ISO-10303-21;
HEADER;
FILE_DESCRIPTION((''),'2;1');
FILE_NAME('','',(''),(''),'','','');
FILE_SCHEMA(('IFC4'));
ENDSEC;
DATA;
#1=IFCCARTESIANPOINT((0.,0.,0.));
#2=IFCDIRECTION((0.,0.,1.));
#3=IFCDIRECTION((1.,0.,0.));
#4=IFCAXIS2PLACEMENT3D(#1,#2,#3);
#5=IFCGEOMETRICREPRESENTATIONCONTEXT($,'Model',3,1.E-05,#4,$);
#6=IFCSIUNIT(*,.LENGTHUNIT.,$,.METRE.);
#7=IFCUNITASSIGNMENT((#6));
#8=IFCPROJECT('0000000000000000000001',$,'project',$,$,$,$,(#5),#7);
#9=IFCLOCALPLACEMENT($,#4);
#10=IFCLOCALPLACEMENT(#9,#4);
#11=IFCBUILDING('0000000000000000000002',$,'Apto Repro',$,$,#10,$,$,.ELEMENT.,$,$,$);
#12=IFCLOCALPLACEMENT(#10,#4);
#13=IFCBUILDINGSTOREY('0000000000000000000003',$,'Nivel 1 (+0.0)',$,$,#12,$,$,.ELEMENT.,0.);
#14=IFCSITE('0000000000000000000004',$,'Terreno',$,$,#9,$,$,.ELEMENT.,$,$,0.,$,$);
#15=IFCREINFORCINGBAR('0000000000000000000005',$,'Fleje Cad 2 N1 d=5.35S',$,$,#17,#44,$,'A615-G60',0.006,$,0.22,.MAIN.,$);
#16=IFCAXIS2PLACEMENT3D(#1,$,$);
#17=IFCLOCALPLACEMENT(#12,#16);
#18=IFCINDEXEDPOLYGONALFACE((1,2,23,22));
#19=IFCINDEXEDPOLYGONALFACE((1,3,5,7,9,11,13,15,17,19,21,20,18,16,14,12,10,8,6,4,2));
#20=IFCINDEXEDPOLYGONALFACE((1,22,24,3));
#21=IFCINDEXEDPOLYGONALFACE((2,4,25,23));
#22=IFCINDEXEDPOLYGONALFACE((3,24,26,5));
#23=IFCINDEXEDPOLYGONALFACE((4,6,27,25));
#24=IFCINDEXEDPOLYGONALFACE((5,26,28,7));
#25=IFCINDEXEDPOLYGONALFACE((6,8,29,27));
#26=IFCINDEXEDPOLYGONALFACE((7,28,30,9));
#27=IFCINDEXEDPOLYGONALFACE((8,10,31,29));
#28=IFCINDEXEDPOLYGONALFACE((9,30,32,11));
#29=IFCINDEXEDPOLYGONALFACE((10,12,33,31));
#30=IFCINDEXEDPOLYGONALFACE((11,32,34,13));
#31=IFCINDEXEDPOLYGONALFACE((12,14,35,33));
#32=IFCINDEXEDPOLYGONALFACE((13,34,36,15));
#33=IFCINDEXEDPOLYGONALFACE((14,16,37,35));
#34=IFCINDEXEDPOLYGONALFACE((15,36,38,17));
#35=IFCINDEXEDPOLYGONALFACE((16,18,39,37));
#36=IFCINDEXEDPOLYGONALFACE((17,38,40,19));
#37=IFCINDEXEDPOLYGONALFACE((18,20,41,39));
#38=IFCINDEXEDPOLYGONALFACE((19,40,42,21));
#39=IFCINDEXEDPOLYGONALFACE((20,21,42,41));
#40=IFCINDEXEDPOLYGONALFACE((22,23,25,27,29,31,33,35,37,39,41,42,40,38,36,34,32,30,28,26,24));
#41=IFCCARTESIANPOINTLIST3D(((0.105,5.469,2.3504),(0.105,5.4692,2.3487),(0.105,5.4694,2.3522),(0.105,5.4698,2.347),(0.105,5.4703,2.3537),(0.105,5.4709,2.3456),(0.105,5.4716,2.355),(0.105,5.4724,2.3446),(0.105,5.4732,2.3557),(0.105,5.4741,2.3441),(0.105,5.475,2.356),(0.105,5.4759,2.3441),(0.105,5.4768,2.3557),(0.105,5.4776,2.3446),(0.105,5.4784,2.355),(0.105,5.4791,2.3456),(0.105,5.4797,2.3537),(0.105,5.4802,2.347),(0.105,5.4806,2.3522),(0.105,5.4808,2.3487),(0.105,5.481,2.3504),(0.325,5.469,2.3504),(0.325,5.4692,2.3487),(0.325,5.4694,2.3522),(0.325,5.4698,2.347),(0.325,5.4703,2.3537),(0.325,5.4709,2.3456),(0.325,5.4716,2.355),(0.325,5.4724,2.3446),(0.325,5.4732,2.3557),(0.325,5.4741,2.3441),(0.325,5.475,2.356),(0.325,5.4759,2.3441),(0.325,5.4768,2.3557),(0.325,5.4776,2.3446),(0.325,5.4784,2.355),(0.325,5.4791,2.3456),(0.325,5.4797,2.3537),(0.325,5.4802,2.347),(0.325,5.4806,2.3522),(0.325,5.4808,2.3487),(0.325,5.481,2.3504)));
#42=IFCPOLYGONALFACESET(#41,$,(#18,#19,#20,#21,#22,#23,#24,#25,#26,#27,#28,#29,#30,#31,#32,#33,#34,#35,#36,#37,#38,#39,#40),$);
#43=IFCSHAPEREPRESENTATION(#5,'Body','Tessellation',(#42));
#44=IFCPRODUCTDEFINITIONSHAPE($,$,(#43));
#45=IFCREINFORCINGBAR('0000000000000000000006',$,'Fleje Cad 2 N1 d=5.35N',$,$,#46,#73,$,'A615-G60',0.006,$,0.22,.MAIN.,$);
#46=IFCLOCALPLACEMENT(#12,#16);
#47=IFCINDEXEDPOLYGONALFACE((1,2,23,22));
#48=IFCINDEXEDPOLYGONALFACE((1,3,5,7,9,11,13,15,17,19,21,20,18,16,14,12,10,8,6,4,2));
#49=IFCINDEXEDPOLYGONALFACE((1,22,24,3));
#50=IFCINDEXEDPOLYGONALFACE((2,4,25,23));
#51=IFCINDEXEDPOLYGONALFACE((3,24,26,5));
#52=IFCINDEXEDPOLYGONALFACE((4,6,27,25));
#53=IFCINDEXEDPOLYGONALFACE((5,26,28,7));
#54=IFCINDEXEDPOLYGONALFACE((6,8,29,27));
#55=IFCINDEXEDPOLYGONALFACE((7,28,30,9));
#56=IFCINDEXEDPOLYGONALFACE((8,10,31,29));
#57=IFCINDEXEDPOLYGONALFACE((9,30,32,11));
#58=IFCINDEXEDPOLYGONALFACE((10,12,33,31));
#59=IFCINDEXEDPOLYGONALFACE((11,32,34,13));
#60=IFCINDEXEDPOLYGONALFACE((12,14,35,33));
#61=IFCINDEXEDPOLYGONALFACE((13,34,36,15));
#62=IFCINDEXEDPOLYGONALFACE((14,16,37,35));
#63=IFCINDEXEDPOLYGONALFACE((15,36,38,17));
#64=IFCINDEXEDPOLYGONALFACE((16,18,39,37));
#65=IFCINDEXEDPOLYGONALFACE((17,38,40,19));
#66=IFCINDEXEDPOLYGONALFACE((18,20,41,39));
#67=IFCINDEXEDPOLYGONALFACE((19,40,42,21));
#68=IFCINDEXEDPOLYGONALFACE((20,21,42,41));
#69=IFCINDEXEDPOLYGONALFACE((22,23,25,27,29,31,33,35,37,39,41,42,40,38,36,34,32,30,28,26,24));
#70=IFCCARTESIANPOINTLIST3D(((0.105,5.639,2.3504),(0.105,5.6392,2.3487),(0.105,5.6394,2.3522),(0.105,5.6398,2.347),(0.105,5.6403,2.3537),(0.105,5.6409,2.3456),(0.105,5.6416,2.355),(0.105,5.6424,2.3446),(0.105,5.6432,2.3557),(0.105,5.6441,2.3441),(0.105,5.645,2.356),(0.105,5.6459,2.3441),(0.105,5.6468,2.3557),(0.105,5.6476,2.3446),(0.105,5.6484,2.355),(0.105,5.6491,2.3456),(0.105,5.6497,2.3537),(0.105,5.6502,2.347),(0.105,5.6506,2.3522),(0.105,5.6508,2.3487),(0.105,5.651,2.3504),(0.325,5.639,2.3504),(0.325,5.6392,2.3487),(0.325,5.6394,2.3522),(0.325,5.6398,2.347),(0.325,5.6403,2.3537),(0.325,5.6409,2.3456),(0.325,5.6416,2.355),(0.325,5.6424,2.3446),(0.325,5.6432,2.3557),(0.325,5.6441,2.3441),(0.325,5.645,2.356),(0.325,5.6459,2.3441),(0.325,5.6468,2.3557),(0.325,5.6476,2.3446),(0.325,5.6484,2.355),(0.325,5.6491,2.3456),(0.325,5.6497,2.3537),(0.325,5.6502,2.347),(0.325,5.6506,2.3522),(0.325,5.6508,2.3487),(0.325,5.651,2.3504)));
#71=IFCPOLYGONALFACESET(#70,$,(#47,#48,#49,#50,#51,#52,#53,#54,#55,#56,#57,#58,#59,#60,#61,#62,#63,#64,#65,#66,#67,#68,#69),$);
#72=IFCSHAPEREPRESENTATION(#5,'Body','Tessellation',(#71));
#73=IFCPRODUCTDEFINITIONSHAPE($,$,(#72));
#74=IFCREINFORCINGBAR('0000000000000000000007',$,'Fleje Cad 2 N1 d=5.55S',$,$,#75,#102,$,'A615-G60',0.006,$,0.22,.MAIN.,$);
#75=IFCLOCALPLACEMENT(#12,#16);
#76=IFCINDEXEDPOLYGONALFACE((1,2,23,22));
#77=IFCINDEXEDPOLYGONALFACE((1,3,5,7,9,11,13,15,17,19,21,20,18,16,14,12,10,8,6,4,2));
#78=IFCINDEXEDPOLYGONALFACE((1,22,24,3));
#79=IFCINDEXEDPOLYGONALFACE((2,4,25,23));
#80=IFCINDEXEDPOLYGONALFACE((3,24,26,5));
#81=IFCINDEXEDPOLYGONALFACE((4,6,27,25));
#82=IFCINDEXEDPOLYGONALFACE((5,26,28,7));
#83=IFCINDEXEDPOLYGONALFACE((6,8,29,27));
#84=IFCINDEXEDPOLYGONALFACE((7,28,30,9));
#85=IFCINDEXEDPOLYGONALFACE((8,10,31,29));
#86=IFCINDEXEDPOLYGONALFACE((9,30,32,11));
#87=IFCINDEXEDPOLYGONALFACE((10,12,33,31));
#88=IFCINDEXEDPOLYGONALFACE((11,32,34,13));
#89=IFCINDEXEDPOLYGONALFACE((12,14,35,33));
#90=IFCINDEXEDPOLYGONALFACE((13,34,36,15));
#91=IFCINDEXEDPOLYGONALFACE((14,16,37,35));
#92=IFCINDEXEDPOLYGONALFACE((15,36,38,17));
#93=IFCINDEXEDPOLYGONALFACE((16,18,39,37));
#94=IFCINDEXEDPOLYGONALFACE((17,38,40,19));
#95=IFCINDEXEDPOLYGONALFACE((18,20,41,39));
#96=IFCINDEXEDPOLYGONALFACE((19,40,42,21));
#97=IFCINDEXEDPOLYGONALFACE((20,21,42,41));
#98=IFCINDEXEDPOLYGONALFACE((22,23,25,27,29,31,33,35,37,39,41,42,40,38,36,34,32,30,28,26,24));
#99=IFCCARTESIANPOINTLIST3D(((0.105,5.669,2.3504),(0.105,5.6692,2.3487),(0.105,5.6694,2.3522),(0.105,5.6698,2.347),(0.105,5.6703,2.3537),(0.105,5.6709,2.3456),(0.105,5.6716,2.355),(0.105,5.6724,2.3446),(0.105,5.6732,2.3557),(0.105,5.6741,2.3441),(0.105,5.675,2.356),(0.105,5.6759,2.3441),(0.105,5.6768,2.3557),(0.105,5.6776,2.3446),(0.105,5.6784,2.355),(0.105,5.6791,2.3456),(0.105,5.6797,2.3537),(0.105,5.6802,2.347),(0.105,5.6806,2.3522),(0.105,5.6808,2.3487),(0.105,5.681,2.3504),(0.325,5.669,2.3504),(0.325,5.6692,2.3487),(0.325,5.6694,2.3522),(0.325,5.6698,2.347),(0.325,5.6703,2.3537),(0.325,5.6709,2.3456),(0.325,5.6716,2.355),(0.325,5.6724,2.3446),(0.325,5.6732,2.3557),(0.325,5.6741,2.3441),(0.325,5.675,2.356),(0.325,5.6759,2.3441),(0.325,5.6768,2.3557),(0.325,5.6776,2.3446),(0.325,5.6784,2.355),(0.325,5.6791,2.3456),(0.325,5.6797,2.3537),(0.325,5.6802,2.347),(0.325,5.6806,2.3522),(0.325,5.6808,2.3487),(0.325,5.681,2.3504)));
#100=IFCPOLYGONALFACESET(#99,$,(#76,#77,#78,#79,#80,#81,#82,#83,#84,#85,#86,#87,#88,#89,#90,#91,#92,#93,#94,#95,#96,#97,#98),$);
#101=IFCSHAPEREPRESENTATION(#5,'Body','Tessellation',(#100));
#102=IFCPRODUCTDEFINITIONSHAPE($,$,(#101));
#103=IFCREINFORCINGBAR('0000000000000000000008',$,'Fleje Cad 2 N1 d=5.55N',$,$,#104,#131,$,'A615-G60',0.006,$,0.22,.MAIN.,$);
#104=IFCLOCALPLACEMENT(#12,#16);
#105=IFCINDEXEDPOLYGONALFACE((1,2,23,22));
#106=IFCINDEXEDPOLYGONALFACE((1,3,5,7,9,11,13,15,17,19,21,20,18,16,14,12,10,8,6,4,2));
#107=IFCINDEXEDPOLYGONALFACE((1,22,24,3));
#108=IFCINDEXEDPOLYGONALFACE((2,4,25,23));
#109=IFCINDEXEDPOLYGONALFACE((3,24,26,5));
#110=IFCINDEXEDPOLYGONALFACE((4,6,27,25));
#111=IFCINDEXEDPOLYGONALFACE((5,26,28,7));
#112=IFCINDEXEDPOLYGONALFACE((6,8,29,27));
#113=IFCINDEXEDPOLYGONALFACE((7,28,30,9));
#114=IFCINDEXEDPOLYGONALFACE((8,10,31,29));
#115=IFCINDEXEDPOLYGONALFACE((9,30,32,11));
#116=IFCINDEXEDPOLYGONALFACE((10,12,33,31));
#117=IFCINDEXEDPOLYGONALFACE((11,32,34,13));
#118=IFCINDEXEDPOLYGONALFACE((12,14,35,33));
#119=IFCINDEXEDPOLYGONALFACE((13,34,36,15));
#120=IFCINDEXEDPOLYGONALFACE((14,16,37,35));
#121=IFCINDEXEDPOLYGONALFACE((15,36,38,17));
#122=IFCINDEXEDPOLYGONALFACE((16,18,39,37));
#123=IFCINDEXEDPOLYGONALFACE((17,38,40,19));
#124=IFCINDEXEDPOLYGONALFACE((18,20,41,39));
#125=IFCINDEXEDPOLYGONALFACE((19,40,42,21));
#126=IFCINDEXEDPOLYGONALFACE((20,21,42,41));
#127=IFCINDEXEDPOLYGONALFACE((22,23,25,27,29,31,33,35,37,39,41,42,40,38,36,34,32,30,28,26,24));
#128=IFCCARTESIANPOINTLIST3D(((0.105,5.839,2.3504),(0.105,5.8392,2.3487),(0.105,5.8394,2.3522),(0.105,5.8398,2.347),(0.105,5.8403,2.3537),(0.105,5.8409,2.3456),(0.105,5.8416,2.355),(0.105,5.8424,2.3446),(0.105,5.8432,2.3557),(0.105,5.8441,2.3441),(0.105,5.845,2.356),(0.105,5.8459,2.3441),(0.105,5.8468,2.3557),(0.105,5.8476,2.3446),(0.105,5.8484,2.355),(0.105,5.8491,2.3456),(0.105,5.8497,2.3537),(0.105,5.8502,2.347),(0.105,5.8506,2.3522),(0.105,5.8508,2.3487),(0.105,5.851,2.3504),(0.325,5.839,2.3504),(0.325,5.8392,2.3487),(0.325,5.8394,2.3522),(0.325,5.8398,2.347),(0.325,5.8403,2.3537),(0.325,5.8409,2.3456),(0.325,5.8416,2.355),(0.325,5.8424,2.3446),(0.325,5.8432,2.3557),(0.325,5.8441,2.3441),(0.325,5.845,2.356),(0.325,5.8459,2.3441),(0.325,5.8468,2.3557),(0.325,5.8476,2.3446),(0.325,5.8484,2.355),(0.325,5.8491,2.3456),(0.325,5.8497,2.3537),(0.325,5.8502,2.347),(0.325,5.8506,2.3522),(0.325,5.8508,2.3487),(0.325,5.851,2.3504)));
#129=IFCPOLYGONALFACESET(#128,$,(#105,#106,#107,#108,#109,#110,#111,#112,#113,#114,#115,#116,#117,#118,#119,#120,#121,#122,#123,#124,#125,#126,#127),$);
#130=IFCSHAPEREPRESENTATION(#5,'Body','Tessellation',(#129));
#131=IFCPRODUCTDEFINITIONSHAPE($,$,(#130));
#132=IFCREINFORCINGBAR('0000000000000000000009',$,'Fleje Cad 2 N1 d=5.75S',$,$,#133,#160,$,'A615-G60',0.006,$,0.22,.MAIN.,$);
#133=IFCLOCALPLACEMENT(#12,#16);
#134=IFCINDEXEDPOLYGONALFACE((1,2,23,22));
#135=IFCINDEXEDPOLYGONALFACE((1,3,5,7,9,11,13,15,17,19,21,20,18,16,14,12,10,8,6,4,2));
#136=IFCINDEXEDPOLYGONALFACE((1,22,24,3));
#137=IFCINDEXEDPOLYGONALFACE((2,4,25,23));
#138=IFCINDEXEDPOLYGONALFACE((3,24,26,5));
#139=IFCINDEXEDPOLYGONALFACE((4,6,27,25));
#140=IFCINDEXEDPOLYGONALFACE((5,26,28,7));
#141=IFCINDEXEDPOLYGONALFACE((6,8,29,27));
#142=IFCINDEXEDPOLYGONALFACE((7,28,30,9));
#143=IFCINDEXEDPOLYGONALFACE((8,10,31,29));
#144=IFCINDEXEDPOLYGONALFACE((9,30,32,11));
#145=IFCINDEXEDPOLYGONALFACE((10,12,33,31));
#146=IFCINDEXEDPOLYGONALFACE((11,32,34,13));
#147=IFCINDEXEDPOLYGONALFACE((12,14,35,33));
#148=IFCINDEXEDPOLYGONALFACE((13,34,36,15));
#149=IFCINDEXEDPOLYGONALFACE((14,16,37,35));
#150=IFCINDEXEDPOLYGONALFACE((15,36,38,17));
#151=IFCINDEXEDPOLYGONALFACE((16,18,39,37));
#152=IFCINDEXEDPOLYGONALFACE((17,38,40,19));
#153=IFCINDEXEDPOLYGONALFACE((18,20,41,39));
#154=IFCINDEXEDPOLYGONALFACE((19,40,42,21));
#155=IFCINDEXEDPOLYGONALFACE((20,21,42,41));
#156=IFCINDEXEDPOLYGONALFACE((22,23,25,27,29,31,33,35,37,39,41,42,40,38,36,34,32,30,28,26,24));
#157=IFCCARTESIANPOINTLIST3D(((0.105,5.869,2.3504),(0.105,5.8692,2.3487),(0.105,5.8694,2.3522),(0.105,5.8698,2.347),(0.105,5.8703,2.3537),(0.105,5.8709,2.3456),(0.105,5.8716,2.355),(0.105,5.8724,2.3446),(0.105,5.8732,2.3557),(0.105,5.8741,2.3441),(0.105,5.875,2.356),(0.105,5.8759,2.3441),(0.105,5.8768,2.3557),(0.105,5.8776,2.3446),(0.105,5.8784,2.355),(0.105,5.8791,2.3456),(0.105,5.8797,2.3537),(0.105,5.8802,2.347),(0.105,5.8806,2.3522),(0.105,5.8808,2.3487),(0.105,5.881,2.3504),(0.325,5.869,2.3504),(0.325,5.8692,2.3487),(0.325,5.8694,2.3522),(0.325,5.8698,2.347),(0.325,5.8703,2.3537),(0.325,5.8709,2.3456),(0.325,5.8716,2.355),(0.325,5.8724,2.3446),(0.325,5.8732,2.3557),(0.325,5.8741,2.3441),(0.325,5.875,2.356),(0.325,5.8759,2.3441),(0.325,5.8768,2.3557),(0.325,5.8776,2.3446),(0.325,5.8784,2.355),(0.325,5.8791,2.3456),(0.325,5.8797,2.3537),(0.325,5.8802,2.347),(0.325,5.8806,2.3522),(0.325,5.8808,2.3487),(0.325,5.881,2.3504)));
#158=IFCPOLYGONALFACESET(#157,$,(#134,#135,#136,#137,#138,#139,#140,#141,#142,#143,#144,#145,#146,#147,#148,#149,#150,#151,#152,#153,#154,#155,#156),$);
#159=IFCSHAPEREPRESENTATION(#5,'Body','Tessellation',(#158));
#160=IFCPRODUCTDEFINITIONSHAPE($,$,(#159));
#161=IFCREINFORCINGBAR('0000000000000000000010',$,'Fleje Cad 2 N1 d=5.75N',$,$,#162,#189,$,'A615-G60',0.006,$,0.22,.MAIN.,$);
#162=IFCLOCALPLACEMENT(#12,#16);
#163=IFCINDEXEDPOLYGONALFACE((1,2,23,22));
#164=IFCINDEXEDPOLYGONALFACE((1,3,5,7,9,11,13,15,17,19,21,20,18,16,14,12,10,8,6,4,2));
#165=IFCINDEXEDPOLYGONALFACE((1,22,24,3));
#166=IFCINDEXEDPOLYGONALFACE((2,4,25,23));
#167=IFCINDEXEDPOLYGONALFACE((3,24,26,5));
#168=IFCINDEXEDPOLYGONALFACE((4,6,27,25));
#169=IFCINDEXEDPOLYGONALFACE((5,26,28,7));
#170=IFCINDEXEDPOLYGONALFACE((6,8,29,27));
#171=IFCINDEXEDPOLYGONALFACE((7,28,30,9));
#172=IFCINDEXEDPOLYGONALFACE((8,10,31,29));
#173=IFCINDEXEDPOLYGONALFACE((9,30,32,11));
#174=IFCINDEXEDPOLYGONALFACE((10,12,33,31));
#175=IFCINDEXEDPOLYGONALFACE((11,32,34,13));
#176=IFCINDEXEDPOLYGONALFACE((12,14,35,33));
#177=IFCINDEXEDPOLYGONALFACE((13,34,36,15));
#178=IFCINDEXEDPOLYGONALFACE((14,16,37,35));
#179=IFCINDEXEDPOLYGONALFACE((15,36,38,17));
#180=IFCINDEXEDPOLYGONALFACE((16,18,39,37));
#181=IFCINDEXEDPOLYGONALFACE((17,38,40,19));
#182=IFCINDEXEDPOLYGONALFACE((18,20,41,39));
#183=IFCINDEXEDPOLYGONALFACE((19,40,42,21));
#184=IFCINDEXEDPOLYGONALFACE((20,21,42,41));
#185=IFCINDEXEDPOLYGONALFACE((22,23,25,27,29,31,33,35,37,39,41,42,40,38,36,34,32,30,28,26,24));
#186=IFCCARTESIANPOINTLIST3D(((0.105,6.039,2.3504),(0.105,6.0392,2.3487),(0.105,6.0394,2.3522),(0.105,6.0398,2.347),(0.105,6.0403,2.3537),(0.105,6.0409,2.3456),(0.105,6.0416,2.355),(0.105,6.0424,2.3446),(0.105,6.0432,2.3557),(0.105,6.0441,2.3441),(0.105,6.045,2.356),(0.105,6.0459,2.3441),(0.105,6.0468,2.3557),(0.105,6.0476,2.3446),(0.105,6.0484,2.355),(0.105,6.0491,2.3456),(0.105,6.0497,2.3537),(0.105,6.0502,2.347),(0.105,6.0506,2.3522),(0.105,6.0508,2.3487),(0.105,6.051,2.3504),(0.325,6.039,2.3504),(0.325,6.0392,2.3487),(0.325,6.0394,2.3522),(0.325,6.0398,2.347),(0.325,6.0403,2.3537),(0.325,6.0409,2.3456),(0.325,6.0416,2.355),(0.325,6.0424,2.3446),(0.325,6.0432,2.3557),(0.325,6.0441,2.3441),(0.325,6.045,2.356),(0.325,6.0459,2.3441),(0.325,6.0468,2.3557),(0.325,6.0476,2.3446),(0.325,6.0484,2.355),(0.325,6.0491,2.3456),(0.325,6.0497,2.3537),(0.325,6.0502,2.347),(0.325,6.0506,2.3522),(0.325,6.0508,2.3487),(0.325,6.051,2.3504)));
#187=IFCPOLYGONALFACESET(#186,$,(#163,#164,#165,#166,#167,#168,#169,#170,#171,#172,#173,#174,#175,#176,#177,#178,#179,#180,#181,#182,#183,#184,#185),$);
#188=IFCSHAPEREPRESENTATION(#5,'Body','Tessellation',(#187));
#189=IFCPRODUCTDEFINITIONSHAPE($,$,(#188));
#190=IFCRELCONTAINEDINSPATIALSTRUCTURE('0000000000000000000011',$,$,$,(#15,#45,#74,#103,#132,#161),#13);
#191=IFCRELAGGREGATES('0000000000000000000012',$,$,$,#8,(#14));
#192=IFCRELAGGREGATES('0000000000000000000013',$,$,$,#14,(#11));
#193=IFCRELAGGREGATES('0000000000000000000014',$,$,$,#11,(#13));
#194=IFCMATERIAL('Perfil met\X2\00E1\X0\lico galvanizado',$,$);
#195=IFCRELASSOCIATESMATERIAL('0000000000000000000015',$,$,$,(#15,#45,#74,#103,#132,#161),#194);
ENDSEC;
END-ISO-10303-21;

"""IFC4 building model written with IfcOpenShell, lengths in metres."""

from ifc_helpers import new_model, si_unit, frame, origin_with_axes, origin_2d_with_axis, place, context, project, spatial, circle, extrude, material, element, save


model = new_model("IFC4")

# Units and contexts
model_context = context("Model", 3, precision=1e-05, world=origin_with_axes())
ifc_project = project(units=[si_unit("LENGTHUNIT", "METRE")], contexts=[model_context])

# Site, building, storey
site_placement = place(None, origin_with_axes())
site = spatial("IfcSite", under=ifc_project, at=site_placement, Name="Terreno", CompositionType="ELEMENT", RefElevation=0.0)
building_placement = place(site_placement, origin_with_axes())
building = spatial("IfcBuilding", under=site, at=building_placement, Name="Apto Repro", CompositionType="ELEMENT")
storey_placement = place(building_placement, origin_with_axes())
storey = spatial("IfcBuildingStorey", under=building, at=storey_placement, Name="Nivel 1 (+0.0)", CompositionType="ELEMENT", Elevation=0.0)

# Reinforcing bars
ifc_material = material(Name="Perfil metálico galvanizado")
reinforcing_bar_1_placement = place(storey_placement, origin_with_axes())
element("IfcReinforcingBar", 1, at=reinforcing_bar_1_placement, inside=storey, material=ifc_material, Name="Fleje Cad 2 N1 d=5.35S", SteelGrade="A615-G60", BarLength=0.22, NominalDiameter=0.006, PredefinedType="MAIN", context=model_context, shape_type="SweptSolid", body=[
    extrude(circle(Radius=0.006, at=origin_2d_with_axis()), frame((0.105, 5.475, 2.35), z_axis=(1.0, 0.0, 0.0), x_axis=(0.0, 0.0, 1.0)), (0.0, 0.0, 1.0), 0.22),
])
reinforcing_bar_2_placement = place(storey_placement, origin_with_axes())
element("IfcReinforcingBar", 2, at=reinforcing_bar_2_placement, inside=storey, material=ifc_material, Name="Fleje Cad 2 N1 d=5.35N", SteelGrade="A615-G60", BarLength=0.22, NominalDiameter=0.006, PredefinedType="MAIN", context=model_context, shape_type="SweptSolid", body=[
    extrude(circle(Radius=0.006, at=origin_2d_with_axis()), frame((0.105, 5.645, 2.35), z_axis=(1.0, 0.0, 0.0), x_axis=(0.0, 0.0, 1.0)), (0.0, 0.0, 1.0), 0.22),
])
reinforcing_bar_3_placement = place(storey_placement, origin_with_axes())
element("IfcReinforcingBar", 3, at=reinforcing_bar_3_placement, inside=storey, material=ifc_material, Name="Fleje Cad 2 N1 d=5.55S", SteelGrade="A615-G60", BarLength=0.22, NominalDiameter=0.006, PredefinedType="MAIN", context=model_context, shape_type="SweptSolid", body=[
    extrude(circle(Radius=0.006, at=origin_2d_with_axis()), frame((0.105, 5.675, 2.35), z_axis=(1.0, 0.0, 0.0), x_axis=(0.0, 0.0, 1.0)), (0.0, 0.0, 1.0), 0.22),
])
reinforcing_bar_4_placement = place(storey_placement, origin_with_axes())
element("IfcReinforcingBar", 4, at=reinforcing_bar_4_placement, inside=storey, material=ifc_material, Name="Fleje Cad 2 N1 d=5.55N", SteelGrade="A615-G60", BarLength=0.22, NominalDiameter=0.006, PredefinedType="MAIN", context=model_context, shape_type="SweptSolid", body=[
    extrude(circle(Radius=0.006, at=origin_2d_with_axis()), frame((0.105, 5.845, 2.35), z_axis=(1.0, 0.0, 0.0), x_axis=(0.0, 0.0, 1.0)), (0.0, 0.0, 1.0), 0.22),
])
reinforcing_bar_5_placement = place(storey_placement, origin_with_axes())
element("IfcReinforcingBar", 5, at=reinforcing_bar_5_placement, inside=storey, material=ifc_material, Name="Fleje Cad 2 N1 d=5.75S", SteelGrade="A615-G60", BarLength=0.22, NominalDiameter=0.006, PredefinedType="MAIN", context=model_context, shape_type="SweptSolid", body=[
    extrude(circle(Radius=0.006, at=origin_2d_with_axis()), frame((0.105, 5.875, 2.35), z_axis=(1.0, 0.0, 0.0), x_axis=(0.0, 0.0, 1.0)), (0.0, 0.0, 1.0), 0.22),
])
reinforcing_bar_6_placement = place(storey_placement, origin_with_axes())
element("IfcReinforcingBar", 6, at=reinforcing_bar_6_placement, inside=storey, material=ifc_material, Name="Fleje Cad 2 N1 d=5.75N", SteelGrade="A615-G60", BarLength=0.22, NominalDiameter=0.006, PredefinedType="MAIN", context=model_context, shape_type="SweptSolid", body=[
    extrude(circle(Radius=0.006, at=origin_2d_with_axis()), frame((0.105, 6.045, 2.35), z_axis=(1.0, 0.0, 0.0), x_axis=(0.0, 0.0, 1.0)), (0.0, 0.0, 1.0), 0.22),
])

save(model, "model.ifc")
